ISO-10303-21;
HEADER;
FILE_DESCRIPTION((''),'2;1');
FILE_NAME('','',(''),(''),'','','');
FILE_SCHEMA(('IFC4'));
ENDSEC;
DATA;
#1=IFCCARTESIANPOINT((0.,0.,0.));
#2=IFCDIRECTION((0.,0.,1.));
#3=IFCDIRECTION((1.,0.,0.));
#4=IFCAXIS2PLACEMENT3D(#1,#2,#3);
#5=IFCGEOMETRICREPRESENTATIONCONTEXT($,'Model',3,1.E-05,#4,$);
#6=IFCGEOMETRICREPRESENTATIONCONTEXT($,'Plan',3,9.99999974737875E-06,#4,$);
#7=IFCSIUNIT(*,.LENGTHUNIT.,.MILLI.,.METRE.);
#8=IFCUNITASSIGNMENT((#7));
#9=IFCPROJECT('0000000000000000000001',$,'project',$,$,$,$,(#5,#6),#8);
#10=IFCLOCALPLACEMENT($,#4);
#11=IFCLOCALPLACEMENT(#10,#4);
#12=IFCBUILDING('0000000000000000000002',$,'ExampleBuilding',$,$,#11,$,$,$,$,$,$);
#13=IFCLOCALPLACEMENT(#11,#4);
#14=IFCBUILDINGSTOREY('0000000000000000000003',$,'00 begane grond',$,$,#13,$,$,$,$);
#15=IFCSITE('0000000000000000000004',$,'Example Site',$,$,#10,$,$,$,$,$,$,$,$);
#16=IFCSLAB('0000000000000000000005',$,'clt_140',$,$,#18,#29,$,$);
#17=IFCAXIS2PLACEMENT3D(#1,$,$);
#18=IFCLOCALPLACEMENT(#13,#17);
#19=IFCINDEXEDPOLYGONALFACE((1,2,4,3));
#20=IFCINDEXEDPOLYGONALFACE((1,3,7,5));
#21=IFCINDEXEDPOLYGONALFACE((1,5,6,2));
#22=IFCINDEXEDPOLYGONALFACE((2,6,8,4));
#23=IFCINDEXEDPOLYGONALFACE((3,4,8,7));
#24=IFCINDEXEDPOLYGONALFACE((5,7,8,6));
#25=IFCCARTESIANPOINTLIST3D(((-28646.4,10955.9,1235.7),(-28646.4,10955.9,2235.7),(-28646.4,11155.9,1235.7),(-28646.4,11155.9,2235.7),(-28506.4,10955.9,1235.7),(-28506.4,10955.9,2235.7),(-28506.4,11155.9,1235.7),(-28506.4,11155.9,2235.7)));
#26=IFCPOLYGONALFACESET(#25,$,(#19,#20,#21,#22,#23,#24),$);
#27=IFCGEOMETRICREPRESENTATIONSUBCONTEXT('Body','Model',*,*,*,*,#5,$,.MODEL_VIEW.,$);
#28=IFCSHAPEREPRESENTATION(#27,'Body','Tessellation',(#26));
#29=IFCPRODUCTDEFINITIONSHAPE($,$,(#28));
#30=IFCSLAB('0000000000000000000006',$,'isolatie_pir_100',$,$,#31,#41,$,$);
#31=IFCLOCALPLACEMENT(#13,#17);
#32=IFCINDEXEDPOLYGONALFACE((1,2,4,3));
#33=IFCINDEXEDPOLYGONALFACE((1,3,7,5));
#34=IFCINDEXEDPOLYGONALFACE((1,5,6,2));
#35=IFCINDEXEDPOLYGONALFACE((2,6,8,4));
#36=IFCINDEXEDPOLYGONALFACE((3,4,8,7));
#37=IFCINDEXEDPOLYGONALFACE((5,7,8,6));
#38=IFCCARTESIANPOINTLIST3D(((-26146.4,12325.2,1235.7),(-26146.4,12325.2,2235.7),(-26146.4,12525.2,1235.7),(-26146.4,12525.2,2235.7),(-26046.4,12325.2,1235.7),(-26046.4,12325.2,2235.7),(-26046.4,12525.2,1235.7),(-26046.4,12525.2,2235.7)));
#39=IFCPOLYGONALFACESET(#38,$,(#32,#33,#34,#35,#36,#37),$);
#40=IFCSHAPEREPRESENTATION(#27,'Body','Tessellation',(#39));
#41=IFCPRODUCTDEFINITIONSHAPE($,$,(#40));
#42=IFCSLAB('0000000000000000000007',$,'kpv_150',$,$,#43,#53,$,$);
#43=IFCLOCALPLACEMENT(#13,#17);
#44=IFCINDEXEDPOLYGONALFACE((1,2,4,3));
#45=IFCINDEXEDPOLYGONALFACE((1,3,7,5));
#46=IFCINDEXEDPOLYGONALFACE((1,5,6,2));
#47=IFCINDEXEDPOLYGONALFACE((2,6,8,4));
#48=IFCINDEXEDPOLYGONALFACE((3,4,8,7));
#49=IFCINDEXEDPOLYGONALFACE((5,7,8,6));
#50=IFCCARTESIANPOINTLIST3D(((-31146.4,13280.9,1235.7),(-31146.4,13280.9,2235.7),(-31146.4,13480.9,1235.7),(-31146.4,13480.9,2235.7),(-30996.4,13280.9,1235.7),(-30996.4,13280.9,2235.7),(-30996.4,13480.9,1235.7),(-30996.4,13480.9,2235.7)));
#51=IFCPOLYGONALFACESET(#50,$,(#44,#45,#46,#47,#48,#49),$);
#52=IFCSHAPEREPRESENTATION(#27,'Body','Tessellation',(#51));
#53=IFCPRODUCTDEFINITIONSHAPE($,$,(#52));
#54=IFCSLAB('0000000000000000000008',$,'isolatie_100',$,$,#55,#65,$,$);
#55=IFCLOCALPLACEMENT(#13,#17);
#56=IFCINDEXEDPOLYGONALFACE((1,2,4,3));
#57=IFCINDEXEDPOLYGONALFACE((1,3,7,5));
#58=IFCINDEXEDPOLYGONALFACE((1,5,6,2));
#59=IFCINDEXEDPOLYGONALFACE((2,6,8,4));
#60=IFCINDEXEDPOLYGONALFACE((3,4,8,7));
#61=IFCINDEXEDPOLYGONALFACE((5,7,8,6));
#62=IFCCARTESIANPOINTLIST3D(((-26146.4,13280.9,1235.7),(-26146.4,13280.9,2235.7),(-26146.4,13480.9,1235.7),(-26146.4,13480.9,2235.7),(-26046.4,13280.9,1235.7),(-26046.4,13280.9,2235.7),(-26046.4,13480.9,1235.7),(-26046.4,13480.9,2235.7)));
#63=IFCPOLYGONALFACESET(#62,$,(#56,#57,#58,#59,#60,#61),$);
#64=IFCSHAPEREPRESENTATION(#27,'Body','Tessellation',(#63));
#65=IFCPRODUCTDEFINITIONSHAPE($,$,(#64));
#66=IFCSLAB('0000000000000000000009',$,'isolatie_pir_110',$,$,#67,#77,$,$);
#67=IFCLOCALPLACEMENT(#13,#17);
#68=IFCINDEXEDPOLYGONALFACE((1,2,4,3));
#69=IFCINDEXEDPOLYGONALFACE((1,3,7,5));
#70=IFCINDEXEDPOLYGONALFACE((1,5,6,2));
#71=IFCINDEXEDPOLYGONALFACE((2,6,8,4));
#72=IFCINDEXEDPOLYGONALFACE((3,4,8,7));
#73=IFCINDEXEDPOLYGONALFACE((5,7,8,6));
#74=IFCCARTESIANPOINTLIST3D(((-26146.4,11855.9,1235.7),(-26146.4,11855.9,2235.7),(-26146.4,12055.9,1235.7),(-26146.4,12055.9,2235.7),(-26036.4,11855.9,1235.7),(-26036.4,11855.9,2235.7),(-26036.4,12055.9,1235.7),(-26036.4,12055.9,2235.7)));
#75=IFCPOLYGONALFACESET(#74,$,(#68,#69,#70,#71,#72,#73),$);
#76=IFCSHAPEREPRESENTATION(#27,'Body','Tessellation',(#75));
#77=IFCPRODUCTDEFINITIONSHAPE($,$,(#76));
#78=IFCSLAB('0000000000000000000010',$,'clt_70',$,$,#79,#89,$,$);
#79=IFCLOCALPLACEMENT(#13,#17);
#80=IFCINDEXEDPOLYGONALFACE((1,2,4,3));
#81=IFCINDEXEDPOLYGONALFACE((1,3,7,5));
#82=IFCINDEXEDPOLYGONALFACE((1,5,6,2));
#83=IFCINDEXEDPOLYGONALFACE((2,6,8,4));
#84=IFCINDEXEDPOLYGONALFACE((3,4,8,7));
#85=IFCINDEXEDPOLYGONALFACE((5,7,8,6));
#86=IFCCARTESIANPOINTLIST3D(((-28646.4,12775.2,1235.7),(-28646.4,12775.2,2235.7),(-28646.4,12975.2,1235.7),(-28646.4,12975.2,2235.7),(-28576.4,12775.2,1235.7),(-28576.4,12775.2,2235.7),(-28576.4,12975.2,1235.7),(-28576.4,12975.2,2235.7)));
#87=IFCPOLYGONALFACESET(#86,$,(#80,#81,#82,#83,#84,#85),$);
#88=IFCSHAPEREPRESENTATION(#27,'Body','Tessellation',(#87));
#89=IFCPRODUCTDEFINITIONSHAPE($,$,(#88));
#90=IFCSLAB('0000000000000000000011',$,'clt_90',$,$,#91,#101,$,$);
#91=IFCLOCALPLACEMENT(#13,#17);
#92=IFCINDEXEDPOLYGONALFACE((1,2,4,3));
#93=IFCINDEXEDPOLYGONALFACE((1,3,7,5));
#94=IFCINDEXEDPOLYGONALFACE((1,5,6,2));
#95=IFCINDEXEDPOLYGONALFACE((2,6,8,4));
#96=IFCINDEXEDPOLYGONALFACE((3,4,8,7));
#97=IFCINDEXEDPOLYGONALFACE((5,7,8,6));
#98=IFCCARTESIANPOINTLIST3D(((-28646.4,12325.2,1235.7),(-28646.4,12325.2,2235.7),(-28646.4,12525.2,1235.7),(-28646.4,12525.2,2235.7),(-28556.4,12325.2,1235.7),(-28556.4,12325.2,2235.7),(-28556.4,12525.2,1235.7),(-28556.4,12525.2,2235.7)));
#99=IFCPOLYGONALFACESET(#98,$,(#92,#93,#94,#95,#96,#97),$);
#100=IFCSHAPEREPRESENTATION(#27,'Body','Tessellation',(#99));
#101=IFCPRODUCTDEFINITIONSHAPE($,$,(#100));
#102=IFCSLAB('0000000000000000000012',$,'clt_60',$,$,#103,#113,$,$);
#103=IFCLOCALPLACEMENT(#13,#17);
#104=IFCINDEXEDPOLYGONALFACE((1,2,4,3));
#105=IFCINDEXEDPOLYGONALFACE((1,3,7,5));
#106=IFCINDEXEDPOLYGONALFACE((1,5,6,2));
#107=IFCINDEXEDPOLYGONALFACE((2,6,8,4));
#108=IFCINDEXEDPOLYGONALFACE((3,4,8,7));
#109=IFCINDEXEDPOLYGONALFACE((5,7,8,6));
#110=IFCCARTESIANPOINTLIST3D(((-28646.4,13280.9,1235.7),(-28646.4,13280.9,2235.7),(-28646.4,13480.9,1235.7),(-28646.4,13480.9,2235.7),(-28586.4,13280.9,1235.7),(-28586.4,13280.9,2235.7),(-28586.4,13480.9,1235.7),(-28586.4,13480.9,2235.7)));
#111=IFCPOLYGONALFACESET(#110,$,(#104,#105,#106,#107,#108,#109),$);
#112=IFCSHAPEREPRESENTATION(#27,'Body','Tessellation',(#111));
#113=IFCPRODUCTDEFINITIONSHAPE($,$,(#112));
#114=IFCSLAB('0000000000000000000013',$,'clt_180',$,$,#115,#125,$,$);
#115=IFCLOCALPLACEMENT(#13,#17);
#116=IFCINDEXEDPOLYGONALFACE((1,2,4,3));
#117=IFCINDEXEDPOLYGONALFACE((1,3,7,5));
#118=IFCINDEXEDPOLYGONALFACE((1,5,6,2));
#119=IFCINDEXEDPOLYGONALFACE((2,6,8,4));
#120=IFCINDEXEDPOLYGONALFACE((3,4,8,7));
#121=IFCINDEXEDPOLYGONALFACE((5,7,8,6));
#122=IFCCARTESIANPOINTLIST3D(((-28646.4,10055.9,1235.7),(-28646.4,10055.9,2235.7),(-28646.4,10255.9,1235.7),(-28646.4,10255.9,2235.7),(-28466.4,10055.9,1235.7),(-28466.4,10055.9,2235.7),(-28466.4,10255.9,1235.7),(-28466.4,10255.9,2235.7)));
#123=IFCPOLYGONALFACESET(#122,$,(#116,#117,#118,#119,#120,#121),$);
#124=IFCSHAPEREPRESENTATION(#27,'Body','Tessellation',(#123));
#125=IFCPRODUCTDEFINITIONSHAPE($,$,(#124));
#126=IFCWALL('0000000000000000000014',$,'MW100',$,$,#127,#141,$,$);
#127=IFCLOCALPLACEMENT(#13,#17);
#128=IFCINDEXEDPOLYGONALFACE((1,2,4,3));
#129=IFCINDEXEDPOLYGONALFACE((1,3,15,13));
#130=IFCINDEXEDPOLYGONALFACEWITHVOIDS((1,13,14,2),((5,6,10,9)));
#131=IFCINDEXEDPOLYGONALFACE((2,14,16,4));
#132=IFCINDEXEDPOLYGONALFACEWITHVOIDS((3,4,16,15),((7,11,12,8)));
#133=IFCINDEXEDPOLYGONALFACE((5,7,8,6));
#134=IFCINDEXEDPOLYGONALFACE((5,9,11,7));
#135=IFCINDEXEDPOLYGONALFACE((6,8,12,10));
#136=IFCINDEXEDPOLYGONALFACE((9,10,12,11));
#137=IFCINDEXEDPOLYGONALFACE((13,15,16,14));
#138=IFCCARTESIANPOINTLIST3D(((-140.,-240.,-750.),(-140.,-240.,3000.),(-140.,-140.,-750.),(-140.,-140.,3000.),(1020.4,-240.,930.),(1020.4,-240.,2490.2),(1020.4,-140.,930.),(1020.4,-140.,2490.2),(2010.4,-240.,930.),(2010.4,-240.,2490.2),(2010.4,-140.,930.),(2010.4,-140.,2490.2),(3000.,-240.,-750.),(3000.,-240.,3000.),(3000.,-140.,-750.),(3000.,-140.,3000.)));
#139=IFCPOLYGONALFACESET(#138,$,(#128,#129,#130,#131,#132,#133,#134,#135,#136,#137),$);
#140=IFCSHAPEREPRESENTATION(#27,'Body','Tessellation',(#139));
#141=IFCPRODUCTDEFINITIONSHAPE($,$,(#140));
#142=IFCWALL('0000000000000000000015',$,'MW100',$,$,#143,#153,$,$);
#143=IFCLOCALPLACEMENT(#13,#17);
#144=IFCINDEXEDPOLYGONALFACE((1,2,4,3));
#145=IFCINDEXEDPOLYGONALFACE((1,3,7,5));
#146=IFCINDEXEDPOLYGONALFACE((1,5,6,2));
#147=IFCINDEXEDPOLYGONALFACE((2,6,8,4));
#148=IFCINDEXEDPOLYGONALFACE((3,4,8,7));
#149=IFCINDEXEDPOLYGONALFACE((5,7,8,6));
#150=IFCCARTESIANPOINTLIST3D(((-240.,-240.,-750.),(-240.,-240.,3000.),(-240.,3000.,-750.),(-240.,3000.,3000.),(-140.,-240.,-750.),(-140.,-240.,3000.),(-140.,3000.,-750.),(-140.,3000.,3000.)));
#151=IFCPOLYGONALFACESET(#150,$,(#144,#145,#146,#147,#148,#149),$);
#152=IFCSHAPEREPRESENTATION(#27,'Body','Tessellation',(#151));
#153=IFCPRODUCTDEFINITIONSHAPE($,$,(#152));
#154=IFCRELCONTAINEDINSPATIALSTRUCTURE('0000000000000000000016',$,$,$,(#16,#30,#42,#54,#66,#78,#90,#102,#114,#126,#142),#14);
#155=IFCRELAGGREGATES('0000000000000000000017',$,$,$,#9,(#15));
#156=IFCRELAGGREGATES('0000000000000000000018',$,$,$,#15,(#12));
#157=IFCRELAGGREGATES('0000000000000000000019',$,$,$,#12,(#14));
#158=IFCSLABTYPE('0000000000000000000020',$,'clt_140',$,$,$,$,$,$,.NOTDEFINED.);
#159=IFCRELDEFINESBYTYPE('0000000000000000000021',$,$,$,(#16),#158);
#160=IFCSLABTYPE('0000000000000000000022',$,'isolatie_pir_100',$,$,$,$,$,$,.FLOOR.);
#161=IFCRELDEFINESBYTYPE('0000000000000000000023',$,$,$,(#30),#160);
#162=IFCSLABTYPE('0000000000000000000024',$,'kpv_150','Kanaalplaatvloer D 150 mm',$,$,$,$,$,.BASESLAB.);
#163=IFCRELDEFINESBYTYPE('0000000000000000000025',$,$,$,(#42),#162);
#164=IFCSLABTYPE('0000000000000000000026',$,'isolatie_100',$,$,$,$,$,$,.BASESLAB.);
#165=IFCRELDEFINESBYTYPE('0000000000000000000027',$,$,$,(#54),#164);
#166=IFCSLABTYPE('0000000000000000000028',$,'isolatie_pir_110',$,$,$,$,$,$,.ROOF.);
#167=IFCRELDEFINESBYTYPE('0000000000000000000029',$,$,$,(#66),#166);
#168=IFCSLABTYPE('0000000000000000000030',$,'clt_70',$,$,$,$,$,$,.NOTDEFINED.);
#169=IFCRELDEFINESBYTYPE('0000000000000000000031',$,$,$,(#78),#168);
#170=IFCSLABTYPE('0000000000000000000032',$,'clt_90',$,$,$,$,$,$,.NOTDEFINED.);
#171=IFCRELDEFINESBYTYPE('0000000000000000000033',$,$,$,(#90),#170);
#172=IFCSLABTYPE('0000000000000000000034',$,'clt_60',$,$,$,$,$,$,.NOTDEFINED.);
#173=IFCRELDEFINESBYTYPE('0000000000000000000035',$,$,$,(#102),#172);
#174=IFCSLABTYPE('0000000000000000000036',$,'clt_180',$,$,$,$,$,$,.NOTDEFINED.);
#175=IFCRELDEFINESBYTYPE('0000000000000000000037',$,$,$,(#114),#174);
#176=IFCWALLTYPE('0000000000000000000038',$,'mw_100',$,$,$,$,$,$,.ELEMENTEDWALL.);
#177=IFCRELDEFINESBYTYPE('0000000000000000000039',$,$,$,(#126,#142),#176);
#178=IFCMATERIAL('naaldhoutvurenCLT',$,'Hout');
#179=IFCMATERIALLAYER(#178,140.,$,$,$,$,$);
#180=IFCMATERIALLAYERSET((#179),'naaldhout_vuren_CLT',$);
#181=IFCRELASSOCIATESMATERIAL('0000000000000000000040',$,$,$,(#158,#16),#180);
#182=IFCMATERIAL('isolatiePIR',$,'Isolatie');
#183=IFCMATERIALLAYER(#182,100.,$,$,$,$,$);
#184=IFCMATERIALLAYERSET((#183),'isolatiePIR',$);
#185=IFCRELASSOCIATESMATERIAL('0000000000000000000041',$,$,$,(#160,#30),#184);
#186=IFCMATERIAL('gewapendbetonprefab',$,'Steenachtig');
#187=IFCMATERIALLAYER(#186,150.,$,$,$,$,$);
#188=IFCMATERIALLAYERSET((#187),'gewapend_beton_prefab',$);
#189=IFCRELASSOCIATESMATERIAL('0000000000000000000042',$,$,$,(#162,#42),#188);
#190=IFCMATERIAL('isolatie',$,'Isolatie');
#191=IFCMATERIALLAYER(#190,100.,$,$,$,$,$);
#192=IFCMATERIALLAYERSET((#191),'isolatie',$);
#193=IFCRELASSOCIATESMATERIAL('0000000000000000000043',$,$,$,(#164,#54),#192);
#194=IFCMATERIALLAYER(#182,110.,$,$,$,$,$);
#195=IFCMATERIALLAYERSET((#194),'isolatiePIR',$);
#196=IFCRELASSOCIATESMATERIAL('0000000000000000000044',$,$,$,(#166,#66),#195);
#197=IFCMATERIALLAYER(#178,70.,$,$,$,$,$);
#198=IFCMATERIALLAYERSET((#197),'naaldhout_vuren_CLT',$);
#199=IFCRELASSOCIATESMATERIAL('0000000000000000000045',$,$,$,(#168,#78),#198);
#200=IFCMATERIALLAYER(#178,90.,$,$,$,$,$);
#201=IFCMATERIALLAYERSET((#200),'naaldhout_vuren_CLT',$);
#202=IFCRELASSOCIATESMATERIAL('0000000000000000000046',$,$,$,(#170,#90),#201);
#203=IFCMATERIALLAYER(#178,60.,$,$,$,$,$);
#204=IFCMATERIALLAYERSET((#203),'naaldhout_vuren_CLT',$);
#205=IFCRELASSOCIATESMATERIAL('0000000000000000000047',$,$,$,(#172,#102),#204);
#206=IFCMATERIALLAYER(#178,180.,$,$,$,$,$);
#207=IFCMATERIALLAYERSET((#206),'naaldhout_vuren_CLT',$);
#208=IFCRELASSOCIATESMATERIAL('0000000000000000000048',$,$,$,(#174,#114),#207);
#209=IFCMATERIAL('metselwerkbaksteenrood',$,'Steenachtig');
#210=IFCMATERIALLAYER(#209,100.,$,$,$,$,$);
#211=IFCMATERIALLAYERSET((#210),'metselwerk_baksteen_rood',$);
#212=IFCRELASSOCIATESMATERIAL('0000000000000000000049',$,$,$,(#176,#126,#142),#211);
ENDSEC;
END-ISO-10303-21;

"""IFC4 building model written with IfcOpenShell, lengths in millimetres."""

from ifc_helpers import new_model, si_unit, frame, origin_with_axes, place, context, subcontext, project, spatial, polyline, line, indexed_curve, outline, extrude, source, transform, mapped, material, layer, layer_set, layer_usage, type_object, element, save


model = new_model("IFC4")

# Units and contexts
model_context = context("Model", 3, precision=1e-05, world=origin_with_axes())
plan_context = context("Plan", 3, precision=9.99999974737875e-06, world=origin_with_axes())
body_context = subcontext(model_context, "Body", "Model", "MODEL_VIEW")
ifc_project = project(units=[si_unit("LENGTHUNIT", "METRE", prefix="MILLI")], contexts=[model_context, plan_context])

# Site, building, storey
site_placement = place(None, frame((0.0, 0.0, 0.0), z_axis=(0.0, 0.0, 1.0), x_axis=(1.0, 0.0, 0.0)))
site = spatial("IfcSite", under=ifc_project, at=site_placement, Name="Example Site")
building_placement = place(site_placement, frame((0.0, 0.0, 0.0), z_axis=(0.0, 0.0, 1.0), x_axis=(1.0, 0.0, 0.0)))
building = spatial("IfcBuilding", under=site, at=building_placement, Name="ExampleBuilding")
storey_placement = place(building_placement, frame((0.0, 0.0, 0.0), z_axis=(0.0, 0.0, 1.0), x_axis=(1.0, 0.0, 0.0)))
storey = spatial("IfcBuildingStorey", under=building, at=storey_placement, Name="00 begane grond")

# Slabs
ifc_material_1 = material(Name="gewapendbetonprefab", Category="Steenachtig")
ifc_material_2 = material(Name="naaldhoutvurenCLT", Category="Hout")
ifc_layer_1 = layer(ifc_material_2, 140.0)
ifc_layer_set_1 = layer_set([ifc_layer_1], Name="naaldhout_vuren_CLT")
ifc_layer_usage_1 = layer_usage(ifc_layer_set_1, "AXIS3", "POSITIVE", 0.0)
slab_type_1 = type_object("IfcSlabType", Name="clt_140", PredefinedType="NOTDEFINED", material=ifc_layer_set_1)
slab_1_placement = place(storey_placement, frame((-28646.4, 10955.9, 2235.7), z_axis=(1.0, 0.0, 0.0), x_axis=(0.0, 0.0, -1.0)))
element("IfcSlab", 1, at=slab_1_placement, inside=storey, type_object=slab_type_1, material=ifc_layer_usage_1, Name="clt_140", context=body_context, shape_type="SweptSolid", body=[
    extrude(outline(indexed_curve([(1000.0, 200.0), (1000.0, 0.0), (0.0, 0.0), (0.0, 200.0)], segments=[line(3, 2), line(2, 1), line(1, 4), line(4, 3)], self_intersect=False)), None, (0.0, 0.0, 1.0), 140.0),
])
ifc_material_3 = material(Name="isolatiePIR", Category="Isolatie")
ifc_layer_2 = layer(ifc_material_3, 100.0)
ifc_layer_set_2 = layer_set([ifc_layer_2], Name="isolatiePIR")
ifc_layer_usage_2 = layer_usage(ifc_layer_set_2, "AXIS3", "POSITIVE", 0.0)
slab_type_2 = type_object("IfcSlabType", Name="isolatie_pir_100", PredefinedType="FLOOR", material=ifc_layer_set_2)
slab_2_placement = place(storey_placement, frame((-26146.4, 12325.2, 2235.7), z_axis=(1.0, 0.0, 0.0), x_axis=(0.0, 0.0, -1.0)))
element("IfcSlab", 2, at=slab_2_placement, inside=storey, type_object=slab_type_2, material=ifc_layer_usage_2, Name="isolatie_pir_100", context=body_context, shape_type="SweptSolid", body=[
    extrude(outline(polyline([(-100.0, -500.0), (100.0, -500.0), (100.0, 500.0), (-100.0, 500.0), (-100.0, -500.0)])), frame((500.0, 100.0, 0.0), z_axis=(0.0, 0.0, -1.0), x_axis=(0.0, -1.0, 0.0)), (0.0, 0.0, -1.0), 100.0),
])
ifc_layer_3 = layer(ifc_material_1, 150.0)
ifc_layer_set_3 = layer_set([ifc_layer_3], Name="gewapend_beton_prefab")
ifc_layer_usage_3 = layer_usage(ifc_layer_set_3, "AXIS3", "POSITIVE", 0.0)
slab_type_3 = type_object("IfcSlabType", Name="kpv_150", Description="Kanaalplaatvloer D 150 mm", PredefinedType="BASESLAB", material=ifc_layer_set_3)
slab_3_placement = place(storey_placement, frame((-31146.4, 13280.9, 2235.7), z_axis=(1.0, 0.0, 0.0), x_axis=(0.0, 0.0, -1.0)))
element("IfcSlab", 3, at=slab_3_placement, inside=storey, type_object=slab_type_3, material=ifc_layer_usage_3, Name="kpv_150", context=body_context, shape_type="SweptSolid", body=[
    extrude(outline(indexed_curve([(1000.0, 200.0), (1000.0, 0.0), (0.0, 0.0), (0.0, 200.0)], segments=[line(3, 2), line(2, 1), line(1, 4), line(4, 3)], self_intersect=False)), None, (0.0, 0.0, 1.0), 150.0),
])
ifc_material_4 = material(Name="isolatie", Category="Isolatie")
ifc_layer_4 = layer(ifc_material_4, 100.0)
ifc_layer_set_4 = layer_set([ifc_layer_4], Name="isolatie")
ifc_layer_usage_4 = layer_usage(ifc_layer_set_4, "AXIS3", "POSITIVE", 0.0)
slab_type_4 = type_object("IfcSlabType", Name="isolatie_100", PredefinedType="BASESLAB", material=ifc_layer_set_4)
slab_4_placement = place(storey_placement, frame((-26146.4, 13280.9, 2235.7), z_axis=(1.0, 0.0, 0.0), x_axis=(0.0, 0.0, -1.0)))
element("IfcSlab", 4, at=slab_4_placement, inside=storey, type_object=slab_type_4, material=ifc_layer_usage_4, Name="isolatie_100", context=body_context, shape_type="SweptSolid", body=[
    extrude(outline(indexed_curve([(1000.0, 200.0), (1000.0, 0.0), (0.0, 0.0), (0.0, 200.0)], segments=[line(3, 2), line(2, 1), line(1, 4), line(4, 3)], self_intersect=False)), None, (0.0, 0.0, 1.0), 100.0),
])
ifc_layer_5 = layer(ifc_material_3, 110.0)
ifc_layer_set_5 = layer_set([ifc_layer_5], Name="isolatiePIR")
ifc_layer_usage_5 = layer_usage(ifc_layer_set_5, "AXIS3", "POSITIVE", 0.0)
slab_type_5 = type_object("IfcSlabType", Name="isolatie_pir_110", PredefinedType="ROOF", material=ifc_layer_set_5)
slab_5_placement = place(storey_placement, frame((-26146.4, 11855.9, 2235.7), z_axis=(1.0, 0.0, 0.0), x_axis=(0.0, 0.0, -1.0)))
element("IfcSlab", 5, at=slab_5_placement, inside=storey, type_object=slab_type_5, material=ifc_layer_usage_5, Name="isolatie_pir_110", context=body_context, shape_type="SweptSolid", body=[
    extrude(outline(polyline([(-100.0, -500.0), (100.0, -500.0), (100.0, 500.0), (-100.0, 500.0), (-100.0, -500.0)])), frame((500.0, 100.0, 0.0), z_axis=(0.0, 0.0, -1.0), x_axis=(0.0, -1.0, 0.0)), (0.0, 0.0, -1.0), 110.0),
])
ifc_layer_6 = layer(ifc_material_2, 70.0)
ifc_layer_set_6 = layer_set([ifc_layer_6], Name="naaldhout_vuren_CLT")
ifc_layer_usage_6 = layer_usage(ifc_layer_set_6, "AXIS3", "POSITIVE", 0.0)
slab_type_6 = type_object("IfcSlabType", Name="clt_70", PredefinedType="NOTDEFINED", material=ifc_layer_set_6)
slab_6_placement = place(storey_placement, frame((-28576.4, 12875.2, 1735.7), z_axis=(1.0, 0.0, 0.0), x_axis=(0.0, 0.0, -1.0)))
element("IfcSlab", 6, at=slab_6_placement, inside=storey, type_object=slab_type_6, material=ifc_layer_usage_6, Name="clt_70", context=body_context, shape_type="SweptSolid", body=[
    extrude(outline(polyline([(-100.0, -500.0), (100.0, -500.0), (100.0, 500.0), (-100.0, 500.0), (-100.0, -500.0)])), frame((0.0, 0.0, 0.0), z_axis=(0.0, 0.0, -1.0), x_axis=(0.0, -1.0, 0.0)), (0.0, 0.0, 1.0), 70.0),
])
ifc_layer_7 = layer(ifc_material_2, 90.0)
ifc_layer_set_7 = layer_set([ifc_layer_7], Name="naaldhout_vuren_CLT")
ifc_layer_usage_7 = layer_usage(ifc_layer_set_7, "AXIS3", "POSITIVE", 0.0)
slab_type_7 = type_object("IfcSlabType", Name="clt_90", PredefinedType="NOTDEFINED", material=ifc_layer_set_7)
slab_7_placement = place(storey_placement, frame((-28556.4, 12425.2, 1735.7), z_axis=(1.0, 0.0, 0.0), x_axis=(0.0, 0.0, -1.0)))
element("IfcSlab", 7, at=slab_7_placement, inside=storey, type_object=slab_type_7, material=ifc_layer_usage_7, Name="clt_90", context=body_context, shape_type="SweptSolid", body=[
    extrude(outline(polyline([(-100.0, -500.0), (100.0, -500.0), (100.0, 500.0), (-100.0, 500.0), (-100.0, -500.0)])), frame((0.0, 0.0, 0.0), z_axis=(0.0, 0.0, -1.0), x_axis=(0.0, -1.0, 0.0)), (0.0, 0.0, 1.0), 90.0),
])
ifc_layer_8 = layer(ifc_material_2, 60.0)
ifc_layer_set_8 = layer_set([ifc_layer_8], Name="naaldhout_vuren_CLT")
ifc_layer_usage_8 = layer_usage(ifc_layer_set_8, "AXIS3", "POSITIVE", 0.0)
slab_type_8 = type_object("IfcSlabType", Name="clt_60", PredefinedType="NOTDEFINED", material=ifc_layer_set_8)
slab_8_placement = place(storey_placement, frame((-28646.4, 13280.9, 2235.7), z_axis=(1.0, 0.0, 0.0), x_axis=(0.0, 0.0, -1.0)))
element("IfcSlab", 8, at=slab_8_placement, inside=storey, type_object=slab_type_8, material=ifc_layer_usage_8, Name="clt_60", context=body_context, shape_type="SweptSolid", body=[
    extrude(outline(indexed_curve([(1000.0, 200.0), (1000.0, 0.0), (0.0, 0.0), (0.0, 200.0)], segments=[line(3, 2), line(2, 1), line(1, 4), line(4, 3)], self_intersect=False)), None, (0.0, 0.0, 1.0), 60.0),
])
ifc_layer_9 = layer(ifc_material_2, 180.0)
ifc_layer_set_9 = layer_set([ifc_layer_9], Name="naaldhout_vuren_CLT")
ifc_layer_usage_9 = layer_usage(ifc_layer_set_9, "AXIS3", "POSITIVE", 0.0)
slab_type_9 = type_object("IfcSlabType", Name="clt_180", PredefinedType="NOTDEFINED", material=ifc_layer_set_9)
slab_9_placement = place(storey_placement, frame((-28646.4, 10055.9, 2235.7), z_axis=(1.0, 0.0, 0.0), x_axis=(0.0, 0.0, -1.0)))
element("IfcSlab", 9, at=slab_9_placement, inside=storey, type_object=slab_type_9, material=ifc_layer_usage_9, Name="clt_180", context=body_context, shape_type="SweptSolid", body=[
    extrude(outline(indexed_curve([(1000.0, 200.0), (1000.0, 0.0), (0.0, 0.0), (0.0, 200.0)], segments=[line(4, 1), line(1, 2), line(2, 3), line(3, 4)], self_intersect=False)), None, (0.0, 0.0, 1.0), 180.0),
])

# Wall, opening
ifc_material_5 = material(Name="metselwerkbaksteenrood", Category="Steenachtig")
ifc_layer_10 = layer(ifc_material_5, 100.0)
ifc_layer_set_10 = layer_set([ifc_layer_10], Name="metselwerk_baksteen_rood")
ifc_layer_usage_10 = layer_usage(ifc_layer_set_10, "AXIS2", "POSITIVE", 0.0)
wall_type_1 = type_object("IfcWallType", Name="mw_100", PredefinedType="ELEMENTEDWALL", material=ifc_layer_set_10)
wall_1_placement = place(storey_placement, frame((-140.0, -240.0, -750.0), z_axis=(0.0, 0.0, 1.0), x_axis=(1.0, 0.0, 0.0)))
wall_1 = element("IfcWall", 10, at=wall_1_placement, inside=storey, type_object=wall_type_1, material=ifc_layer_usage_10, Name="MW100", context=body_context, shape_type="SweptSolid", body=[
    extrude(outline(indexed_curve([(0.0, 0.0), (0.0, 100.0), (3140.0, 100.0), (3140.0, 0.0), (0.0, 0.0)], self_intersect=False)), origin_with_axes(), (0.0, 0.0, 1.0), 3750.0),
])
shared_shape = source(origin_with_axes(), body_context, "Body", "SweptSolid", [
    extrude(outline(indexed_curve([(0.0, 0.0), (990.0, 0.0), (990.0, 1560.2), (0.0, 1560.2)], segments=[line(1, 2, 3, 4, 1)])), frame((0.0, -600.0, 0.0), z_axis=(0.0, -1.0, 0.0), x_axis=(1.0, 0.0, 0.0)), (0.0, 0.0, -1.0), 1200.0),
])
opening_1_placement = place(wall_1_placement, frame((1160.4, 70.0, 1680.0), z_axis=(0.0, 0.0, 1.0), x_axis=(1.0, 0.0, 0.0)))
element("IfcOpeningElement", 11, at=opening_1_placement, cuts=wall_1, context=body_context, shape_type="MappedRepresentation", body=[
    mapped(shared_shape, transform((0.0, 0.0, 0.0), x_axis=(1.0, 0.0, 0.0), y_axis=(0.0, 1.0, 0.0), z_axis=(0.0, 0.0, 1.0), scale=1.0)),
])

# Wall
ifc_layer_usage_11 = layer_usage(ifc_layer_set_10, "AXIS2", "POSITIVE", 0.0)
wall_2_placement = place(storey_placement, frame((-140.0, -240.0, -750.0), z_axis=(0.0, 0.0, 1.0), x_axis=(0.0, 1.0, 0.0)))
element("IfcWall", 12, at=wall_2_placement, inside=storey, type_object=wall_type_1, material=ifc_layer_usage_11, Name="MW100", context=body_context, shape_type="SweptSolid", body=[
    extrude(outline(indexed_curve([(0.0, 0.0), (0.0, 100.0), (3240.0, 100.0), (3240.0, 0.0), (0.0, 0.0)], self_intersect=False)), origin_with_axes(), (0.0, 0.0, 1.0), 3750.0),
])

save(model, "model.ifc")
